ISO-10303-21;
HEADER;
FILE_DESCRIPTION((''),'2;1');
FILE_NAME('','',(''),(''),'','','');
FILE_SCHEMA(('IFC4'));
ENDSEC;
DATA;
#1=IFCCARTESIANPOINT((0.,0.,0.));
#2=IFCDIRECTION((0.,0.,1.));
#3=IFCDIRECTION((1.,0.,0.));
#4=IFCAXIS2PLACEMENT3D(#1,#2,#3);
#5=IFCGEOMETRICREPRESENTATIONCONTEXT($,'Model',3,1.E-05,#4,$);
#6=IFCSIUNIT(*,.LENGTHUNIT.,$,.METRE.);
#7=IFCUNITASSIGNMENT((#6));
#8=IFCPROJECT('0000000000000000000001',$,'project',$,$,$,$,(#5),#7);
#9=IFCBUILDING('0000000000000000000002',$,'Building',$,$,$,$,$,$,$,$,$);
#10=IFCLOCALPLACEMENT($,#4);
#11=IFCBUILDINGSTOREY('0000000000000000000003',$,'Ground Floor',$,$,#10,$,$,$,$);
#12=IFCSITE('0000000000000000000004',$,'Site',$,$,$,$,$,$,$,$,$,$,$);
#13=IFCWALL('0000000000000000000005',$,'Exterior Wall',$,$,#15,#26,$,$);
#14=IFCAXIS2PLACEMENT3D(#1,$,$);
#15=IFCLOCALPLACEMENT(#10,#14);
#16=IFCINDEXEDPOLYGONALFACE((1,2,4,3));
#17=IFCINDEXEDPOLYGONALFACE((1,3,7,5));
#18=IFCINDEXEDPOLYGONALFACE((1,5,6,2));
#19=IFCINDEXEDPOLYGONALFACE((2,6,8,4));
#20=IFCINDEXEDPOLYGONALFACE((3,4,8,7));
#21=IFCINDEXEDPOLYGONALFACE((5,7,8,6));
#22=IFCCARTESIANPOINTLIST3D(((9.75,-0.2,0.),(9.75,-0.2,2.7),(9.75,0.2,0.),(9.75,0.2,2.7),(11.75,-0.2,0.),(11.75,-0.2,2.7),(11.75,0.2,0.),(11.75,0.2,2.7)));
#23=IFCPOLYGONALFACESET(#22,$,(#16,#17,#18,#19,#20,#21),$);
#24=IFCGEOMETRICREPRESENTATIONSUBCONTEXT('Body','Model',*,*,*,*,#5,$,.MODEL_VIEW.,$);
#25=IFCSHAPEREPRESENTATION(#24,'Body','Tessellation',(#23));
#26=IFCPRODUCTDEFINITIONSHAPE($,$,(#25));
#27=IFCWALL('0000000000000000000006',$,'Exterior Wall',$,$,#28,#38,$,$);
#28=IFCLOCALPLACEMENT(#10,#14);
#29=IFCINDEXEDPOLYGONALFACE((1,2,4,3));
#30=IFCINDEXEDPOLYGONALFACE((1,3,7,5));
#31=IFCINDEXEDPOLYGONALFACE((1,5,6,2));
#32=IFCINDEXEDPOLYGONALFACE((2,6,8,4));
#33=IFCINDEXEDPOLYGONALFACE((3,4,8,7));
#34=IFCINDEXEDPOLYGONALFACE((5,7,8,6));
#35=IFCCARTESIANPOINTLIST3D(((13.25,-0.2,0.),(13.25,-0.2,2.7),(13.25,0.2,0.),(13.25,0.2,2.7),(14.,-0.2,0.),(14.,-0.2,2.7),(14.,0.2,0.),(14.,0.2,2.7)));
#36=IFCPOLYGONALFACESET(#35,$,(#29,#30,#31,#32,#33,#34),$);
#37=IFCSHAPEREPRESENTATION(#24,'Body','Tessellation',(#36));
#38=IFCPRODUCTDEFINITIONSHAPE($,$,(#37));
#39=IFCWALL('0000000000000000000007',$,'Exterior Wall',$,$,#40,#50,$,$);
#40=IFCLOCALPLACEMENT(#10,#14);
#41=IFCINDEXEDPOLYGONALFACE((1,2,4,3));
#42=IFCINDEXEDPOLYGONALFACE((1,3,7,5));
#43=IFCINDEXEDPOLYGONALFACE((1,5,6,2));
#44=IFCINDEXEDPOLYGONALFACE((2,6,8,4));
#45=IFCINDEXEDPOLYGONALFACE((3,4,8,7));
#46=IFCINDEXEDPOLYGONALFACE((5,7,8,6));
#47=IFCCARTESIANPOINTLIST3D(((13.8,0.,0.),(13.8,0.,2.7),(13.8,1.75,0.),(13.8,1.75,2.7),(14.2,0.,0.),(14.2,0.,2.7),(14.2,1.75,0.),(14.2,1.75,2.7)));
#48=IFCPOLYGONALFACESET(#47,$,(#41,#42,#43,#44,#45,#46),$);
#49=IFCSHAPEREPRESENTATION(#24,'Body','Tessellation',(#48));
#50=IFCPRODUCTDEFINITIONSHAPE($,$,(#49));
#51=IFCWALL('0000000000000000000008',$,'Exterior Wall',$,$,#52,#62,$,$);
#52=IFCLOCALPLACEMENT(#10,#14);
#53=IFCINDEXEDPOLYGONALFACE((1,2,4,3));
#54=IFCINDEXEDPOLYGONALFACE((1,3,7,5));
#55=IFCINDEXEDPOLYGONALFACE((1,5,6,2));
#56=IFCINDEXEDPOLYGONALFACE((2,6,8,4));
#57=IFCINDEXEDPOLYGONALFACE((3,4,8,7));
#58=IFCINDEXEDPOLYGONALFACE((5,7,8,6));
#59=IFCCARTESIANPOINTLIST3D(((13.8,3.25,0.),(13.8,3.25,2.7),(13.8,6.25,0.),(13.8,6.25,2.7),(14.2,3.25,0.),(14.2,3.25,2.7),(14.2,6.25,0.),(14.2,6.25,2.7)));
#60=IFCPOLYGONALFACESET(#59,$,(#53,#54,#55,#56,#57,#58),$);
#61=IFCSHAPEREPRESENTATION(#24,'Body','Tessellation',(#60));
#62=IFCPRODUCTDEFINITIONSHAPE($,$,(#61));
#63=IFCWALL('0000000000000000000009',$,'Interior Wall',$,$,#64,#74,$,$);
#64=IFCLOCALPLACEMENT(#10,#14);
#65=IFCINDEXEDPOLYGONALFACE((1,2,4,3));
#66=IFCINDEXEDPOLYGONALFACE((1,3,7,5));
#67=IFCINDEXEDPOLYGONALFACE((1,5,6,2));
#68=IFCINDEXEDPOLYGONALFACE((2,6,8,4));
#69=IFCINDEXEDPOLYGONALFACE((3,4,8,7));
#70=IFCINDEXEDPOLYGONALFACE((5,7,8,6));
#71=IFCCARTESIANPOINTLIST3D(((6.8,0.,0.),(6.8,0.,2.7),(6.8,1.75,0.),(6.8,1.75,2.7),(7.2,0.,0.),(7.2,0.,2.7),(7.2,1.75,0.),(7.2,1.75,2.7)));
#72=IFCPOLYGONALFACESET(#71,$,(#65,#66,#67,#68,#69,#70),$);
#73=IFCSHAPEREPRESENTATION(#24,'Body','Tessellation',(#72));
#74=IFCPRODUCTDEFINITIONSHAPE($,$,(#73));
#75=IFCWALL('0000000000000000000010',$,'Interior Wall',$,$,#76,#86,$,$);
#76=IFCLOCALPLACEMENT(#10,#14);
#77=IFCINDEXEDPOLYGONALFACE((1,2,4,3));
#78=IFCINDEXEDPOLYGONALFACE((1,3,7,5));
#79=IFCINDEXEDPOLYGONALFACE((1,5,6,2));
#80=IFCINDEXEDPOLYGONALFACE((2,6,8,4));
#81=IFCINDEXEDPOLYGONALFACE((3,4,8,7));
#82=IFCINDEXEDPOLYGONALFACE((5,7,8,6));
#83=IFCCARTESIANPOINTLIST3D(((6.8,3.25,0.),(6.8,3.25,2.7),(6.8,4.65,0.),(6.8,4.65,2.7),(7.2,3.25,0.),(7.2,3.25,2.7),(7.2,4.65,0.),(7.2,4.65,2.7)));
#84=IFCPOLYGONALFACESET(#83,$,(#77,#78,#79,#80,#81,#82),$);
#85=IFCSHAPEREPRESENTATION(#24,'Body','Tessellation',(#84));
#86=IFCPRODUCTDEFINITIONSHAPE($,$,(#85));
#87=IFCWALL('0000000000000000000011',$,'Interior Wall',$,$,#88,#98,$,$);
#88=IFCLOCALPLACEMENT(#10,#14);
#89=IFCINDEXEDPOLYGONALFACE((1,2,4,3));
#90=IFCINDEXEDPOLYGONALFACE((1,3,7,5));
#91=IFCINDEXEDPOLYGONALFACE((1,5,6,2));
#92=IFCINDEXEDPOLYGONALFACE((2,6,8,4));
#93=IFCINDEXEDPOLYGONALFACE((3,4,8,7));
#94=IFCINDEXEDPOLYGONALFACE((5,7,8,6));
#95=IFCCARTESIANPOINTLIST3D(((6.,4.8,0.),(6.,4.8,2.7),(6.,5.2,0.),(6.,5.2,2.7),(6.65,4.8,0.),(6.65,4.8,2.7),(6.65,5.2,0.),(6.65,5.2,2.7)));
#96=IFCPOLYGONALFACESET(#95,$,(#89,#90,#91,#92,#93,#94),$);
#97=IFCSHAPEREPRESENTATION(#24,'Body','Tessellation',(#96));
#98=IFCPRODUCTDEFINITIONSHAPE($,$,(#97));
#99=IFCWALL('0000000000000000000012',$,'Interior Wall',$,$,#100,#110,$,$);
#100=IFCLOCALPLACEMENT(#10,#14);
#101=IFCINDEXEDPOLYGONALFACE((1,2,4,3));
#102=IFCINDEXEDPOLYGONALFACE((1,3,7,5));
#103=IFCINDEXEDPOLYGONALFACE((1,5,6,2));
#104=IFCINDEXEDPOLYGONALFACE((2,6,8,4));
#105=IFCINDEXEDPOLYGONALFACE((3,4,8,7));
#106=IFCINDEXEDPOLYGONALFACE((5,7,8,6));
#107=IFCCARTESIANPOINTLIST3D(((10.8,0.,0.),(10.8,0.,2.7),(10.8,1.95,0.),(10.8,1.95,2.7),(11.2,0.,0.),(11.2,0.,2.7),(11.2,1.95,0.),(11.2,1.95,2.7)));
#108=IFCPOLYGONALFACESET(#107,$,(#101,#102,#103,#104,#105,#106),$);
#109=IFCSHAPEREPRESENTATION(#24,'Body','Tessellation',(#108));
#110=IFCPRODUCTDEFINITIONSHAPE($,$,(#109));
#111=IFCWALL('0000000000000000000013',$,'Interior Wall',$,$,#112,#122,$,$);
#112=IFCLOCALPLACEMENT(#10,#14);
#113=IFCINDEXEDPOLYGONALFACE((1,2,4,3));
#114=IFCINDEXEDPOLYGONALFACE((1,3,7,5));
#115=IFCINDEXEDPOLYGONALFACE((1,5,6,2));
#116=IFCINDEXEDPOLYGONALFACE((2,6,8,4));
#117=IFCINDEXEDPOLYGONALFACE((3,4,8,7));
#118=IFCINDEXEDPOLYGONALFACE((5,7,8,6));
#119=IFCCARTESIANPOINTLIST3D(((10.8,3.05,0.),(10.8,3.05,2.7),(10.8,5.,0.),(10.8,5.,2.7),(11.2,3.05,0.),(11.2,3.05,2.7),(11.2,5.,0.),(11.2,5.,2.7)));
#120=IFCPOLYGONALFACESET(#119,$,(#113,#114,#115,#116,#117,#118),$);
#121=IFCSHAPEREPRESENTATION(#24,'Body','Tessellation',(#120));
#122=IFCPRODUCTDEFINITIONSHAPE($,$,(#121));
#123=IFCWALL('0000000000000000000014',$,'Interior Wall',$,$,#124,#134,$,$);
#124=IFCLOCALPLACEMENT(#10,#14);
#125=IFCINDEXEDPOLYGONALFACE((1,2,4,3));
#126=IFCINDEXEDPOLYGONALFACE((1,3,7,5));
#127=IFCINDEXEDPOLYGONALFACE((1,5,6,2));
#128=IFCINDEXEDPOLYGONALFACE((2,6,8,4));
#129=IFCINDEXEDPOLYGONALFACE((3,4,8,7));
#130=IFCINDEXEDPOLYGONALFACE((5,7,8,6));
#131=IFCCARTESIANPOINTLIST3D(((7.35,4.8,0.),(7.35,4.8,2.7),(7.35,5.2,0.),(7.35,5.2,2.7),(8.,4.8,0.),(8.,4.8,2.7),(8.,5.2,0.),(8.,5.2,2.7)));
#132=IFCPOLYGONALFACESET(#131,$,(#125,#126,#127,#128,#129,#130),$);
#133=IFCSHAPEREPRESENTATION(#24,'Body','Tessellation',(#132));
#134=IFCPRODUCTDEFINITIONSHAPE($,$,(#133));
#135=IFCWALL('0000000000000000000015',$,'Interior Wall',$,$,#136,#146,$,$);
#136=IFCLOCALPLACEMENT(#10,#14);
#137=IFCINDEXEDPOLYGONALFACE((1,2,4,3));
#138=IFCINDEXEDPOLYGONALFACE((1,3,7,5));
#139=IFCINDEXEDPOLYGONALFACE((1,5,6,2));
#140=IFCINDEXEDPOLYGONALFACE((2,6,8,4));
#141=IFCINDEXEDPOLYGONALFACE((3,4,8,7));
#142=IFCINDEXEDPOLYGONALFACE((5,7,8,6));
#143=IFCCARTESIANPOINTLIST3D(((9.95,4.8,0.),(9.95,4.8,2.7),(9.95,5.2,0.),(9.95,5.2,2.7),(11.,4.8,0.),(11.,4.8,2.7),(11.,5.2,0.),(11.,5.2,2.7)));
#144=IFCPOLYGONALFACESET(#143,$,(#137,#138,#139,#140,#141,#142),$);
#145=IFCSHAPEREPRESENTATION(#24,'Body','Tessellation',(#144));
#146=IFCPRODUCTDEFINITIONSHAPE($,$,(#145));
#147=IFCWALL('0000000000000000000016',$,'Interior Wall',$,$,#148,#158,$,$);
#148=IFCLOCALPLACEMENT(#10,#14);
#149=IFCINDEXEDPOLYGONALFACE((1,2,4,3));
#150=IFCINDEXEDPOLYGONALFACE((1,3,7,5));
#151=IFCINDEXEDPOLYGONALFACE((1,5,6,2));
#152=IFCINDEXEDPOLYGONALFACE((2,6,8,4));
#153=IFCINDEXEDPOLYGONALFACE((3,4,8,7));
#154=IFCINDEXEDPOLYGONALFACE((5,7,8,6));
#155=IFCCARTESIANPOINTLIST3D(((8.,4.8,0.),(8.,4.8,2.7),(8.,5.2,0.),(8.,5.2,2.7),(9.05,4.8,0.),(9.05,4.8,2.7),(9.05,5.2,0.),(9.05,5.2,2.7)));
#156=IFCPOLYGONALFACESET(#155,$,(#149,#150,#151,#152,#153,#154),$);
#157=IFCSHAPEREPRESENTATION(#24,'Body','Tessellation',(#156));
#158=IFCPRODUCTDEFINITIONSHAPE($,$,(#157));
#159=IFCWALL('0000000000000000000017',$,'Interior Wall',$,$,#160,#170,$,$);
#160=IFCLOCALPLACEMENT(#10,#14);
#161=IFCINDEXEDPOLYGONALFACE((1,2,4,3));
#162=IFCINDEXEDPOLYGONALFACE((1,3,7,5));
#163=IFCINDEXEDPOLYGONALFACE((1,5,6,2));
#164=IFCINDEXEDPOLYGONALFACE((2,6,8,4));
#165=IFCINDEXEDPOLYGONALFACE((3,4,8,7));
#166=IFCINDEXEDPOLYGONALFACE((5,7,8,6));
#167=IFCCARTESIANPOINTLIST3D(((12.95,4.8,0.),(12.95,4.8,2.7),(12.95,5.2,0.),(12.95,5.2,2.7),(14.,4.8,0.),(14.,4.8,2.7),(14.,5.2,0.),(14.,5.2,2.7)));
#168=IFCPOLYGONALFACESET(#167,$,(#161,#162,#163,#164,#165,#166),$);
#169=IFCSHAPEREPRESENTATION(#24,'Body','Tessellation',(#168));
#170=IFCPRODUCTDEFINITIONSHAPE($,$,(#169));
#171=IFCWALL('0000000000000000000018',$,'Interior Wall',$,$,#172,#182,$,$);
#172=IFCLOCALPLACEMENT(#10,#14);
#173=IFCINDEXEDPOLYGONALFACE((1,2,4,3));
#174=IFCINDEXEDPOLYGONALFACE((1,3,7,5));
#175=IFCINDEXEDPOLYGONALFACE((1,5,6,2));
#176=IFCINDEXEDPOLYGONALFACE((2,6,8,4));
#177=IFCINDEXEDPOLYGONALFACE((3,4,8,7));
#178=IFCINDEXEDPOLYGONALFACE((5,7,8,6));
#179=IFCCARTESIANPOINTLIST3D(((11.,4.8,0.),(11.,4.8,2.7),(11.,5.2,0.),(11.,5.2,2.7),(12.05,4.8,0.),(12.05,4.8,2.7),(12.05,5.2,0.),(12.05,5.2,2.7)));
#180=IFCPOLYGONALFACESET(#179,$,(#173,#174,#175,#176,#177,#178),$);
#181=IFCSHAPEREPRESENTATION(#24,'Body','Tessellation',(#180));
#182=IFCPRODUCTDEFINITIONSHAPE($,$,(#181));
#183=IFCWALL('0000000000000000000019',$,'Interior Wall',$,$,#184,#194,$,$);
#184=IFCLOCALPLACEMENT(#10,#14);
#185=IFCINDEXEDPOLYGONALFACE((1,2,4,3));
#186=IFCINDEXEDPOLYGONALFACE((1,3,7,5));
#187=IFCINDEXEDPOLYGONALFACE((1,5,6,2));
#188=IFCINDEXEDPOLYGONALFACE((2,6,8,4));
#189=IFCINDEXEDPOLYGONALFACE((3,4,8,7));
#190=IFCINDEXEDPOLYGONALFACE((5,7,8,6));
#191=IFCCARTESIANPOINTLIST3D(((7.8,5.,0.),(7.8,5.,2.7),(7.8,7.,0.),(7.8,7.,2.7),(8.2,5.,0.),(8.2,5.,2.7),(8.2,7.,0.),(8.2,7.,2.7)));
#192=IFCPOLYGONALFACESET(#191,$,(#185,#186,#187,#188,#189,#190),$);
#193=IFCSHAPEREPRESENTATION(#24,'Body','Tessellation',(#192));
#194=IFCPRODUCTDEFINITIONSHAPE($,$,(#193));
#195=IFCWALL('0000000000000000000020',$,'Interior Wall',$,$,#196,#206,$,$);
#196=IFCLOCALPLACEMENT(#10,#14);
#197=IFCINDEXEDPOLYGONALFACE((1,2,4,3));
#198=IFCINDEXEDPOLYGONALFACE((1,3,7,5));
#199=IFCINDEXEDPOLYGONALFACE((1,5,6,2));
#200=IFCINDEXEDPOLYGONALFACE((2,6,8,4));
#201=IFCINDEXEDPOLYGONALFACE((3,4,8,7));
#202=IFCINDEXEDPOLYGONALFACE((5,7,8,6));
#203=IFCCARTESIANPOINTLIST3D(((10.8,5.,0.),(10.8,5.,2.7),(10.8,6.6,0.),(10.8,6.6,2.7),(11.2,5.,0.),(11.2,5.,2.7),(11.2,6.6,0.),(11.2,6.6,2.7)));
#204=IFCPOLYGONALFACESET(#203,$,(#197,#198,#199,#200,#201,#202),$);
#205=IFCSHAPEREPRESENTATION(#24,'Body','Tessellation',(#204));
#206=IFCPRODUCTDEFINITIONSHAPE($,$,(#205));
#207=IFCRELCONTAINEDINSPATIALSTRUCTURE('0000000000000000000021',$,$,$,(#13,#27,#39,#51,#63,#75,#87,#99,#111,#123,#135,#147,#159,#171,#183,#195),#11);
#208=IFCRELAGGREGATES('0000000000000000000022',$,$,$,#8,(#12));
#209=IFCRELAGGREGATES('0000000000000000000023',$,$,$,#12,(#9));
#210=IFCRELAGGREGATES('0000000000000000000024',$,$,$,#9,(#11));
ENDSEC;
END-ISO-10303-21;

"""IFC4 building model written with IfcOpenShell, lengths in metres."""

from ifc_helpers import new_model, si_unit, frame, origin_with_axes, place, context, subcontext, project, spatial, indexed_curve, outline, extrude, element, save


model = new_model("IFC4")

# Units and contexts
model_context = context("Model", 3, precision=1e-05, world=origin_with_axes())
body_context = subcontext(model_context, "Body", "Model", "MODEL_VIEW")
ifc_project = project(units=[si_unit("LENGTHUNIT", "METRE")], contexts=[model_context])

# Site, building, storey
site = spatial("IfcSite", under=ifc_project, Name="Site")
building = spatial("IfcBuilding", under=site, Name="Building")
storey_placement = place(None, origin_with_axes())
storey = spatial("IfcBuildingStorey", under=building, at=storey_placement, Name="Ground Floor")

# Walls
wall_1_placement = place(storey_placement, frame((9.75, 0.0, 0.0), z_axis=(0.0, 0.0, 1.0), x_axis=(1.0, 0.0, 0.0)))
element("IfcWall", 1, at=wall_1_placement, inside=storey, Name="Exterior Wall", context=body_context, shape_type="SweptSolid", body=[
    extrude(outline(indexed_curve([(0.0, 0.0), (0.0, 0.4), (2.0, 0.4), (2.0, 0.0), (0.0, 0.0)], self_intersect=False)), frame((0.0, -0.2, 0.0), z_axis=(0.0, 0.0, 1.0), x_axis=(1.0, 0.0, 0.0)), (0.0, 0.0, 1.0), 2.7),
])
wall_2_placement = place(storey_placement, frame((13.25, 0.0, 0.0), z_axis=(0.0, 0.0, 1.0), x_axis=(1.0, 0.0, 0.0)))
element("IfcWall", 2, at=wall_2_placement, inside=storey, Name="Exterior Wall", context=body_context, shape_type="SweptSolid", body=[
    extrude(outline(indexed_curve([(0.0, 0.0), (0.0, 0.4), (0.75, 0.4), (0.75, 0.0), (0.0, 0.0)], self_intersect=False)), frame((0.0, -0.2, 0.0), z_axis=(0.0, 0.0, 1.0), x_axis=(1.0, 0.0, 0.0)), (0.0, 0.0, 1.0), 2.7),
])
wall_3_placement = place(storey_placement, frame((14.0, 0.0, 0.0), z_axis=(0.0, 0.0, 1.0), x_axis=(0.0, 1.0, 0.0)))
element("IfcWall", 3, at=wall_3_placement, inside=storey, Name="Exterior Wall", context=body_context, shape_type="SweptSolid", body=[
    extrude(outline(indexed_curve([(0.0, 0.0), (0.0, 0.4), (1.75, 0.4), (1.75, 0.0), (0.0, 0.0)], self_intersect=False)), frame((0.0, -0.2, 0.0), z_axis=(0.0, 0.0, 1.0), x_axis=(1.0, 0.0, 0.0)), (0.0, 0.0, 1.0), 2.7),
])
wall_4_placement = place(storey_placement, frame((14.0, 3.25, 0.0), z_axis=(0.0, 0.0, 1.0), x_axis=(0.0, 1.0, 0.0)))
element("IfcWall", 4, at=wall_4_placement, inside=storey, Name="Exterior Wall", context=body_context, shape_type="SweptSolid", body=[
    extrude(outline(indexed_curve([(0.0, 0.0), (0.0, 0.4), (3.0, 0.4), (3.0, 0.0), (0.0, 0.0)], self_intersect=False)), frame((0.0, -0.2, 0.0), z_axis=(0.0, 0.0, 1.0), x_axis=(1.0, 0.0, 0.0)), (0.0, 0.0, 1.0), 2.7),
])
wall_5_placement = place(storey_placement, frame((7.0, 0.0, 0.0), z_axis=(0.0, 0.0, 1.0), x_axis=(0.0, 1.0, 0.0)))
element("IfcWall", 5, at=wall_5_placement, inside=storey, Name="Interior Wall", context=body_context, shape_type="SweptSolid", body=[
    extrude(outline(indexed_curve([(0.0, 0.0), (0.0, 0.4), (1.75, 0.4), (1.75, 0.0), (0.0, 0.0)], self_intersect=False)), frame((0.0, -0.2, 0.0), z_axis=(0.0, 0.0, 1.0), x_axis=(1.0, 0.0, 0.0)), (0.0, 0.0, 1.0), 2.7),
])
wall_6_placement = place(storey_placement, frame((7.0, 3.25, 0.0), z_axis=(0.0, 0.0, 1.0), x_axis=(0.0, 1.0, 0.0)))
element("IfcWall", 6, at=wall_6_placement, inside=storey, Name="Interior Wall", context=body_context, shape_type="SweptSolid", body=[
    extrude(outline(indexed_curve([(0.0, 0.0), (0.0, 0.4), (1.4, 0.4), (1.4, 0.0), (0.0, 0.0)], self_intersect=False)), frame((0.0, -0.2, 0.0), z_axis=(0.0, 0.0, 1.0), x_axis=(1.0, 0.0, 0.0)), (0.0, 0.0, 1.0), 2.7),
])
wall_7_placement = place(storey_placement, frame((6.65, 5.0, 0.0), z_axis=(0.0, 0.0, 1.0), x_axis=(-1.0, 0.0, 0.0)))
element("IfcWall", 7, at=wall_7_placement, inside=storey, Name="Interior Wall", context=body_context, shape_type="SweptSolid", body=[
    extrude(outline(indexed_curve([(0.0, 0.0), (0.0, 0.4), (0.65, 0.4), (0.65, 0.0), (0.0, 0.0)], self_intersect=False)), frame((0.0, -0.2, 0.0), z_axis=(0.0, 0.0, 1.0), x_axis=(1.0, 0.0, 0.0)), (0.0, 0.0, 1.0), 2.7),
])
wall_8_placement = place(storey_placement, frame((11.0, 0.0, 0.0), z_axis=(0.0, 0.0, 1.0), x_axis=(0.0, 1.0, 0.0)))
element("IfcWall", 8, at=wall_8_placement, inside=storey, Name="Interior Wall", context=body_context, shape_type="SweptSolid", body=[
    extrude(outline(indexed_curve([(0.0, 0.0), (0.0, 0.4), (1.95, 0.4), (1.95, 0.0), (0.0, 0.0)], self_intersect=False)), frame((0.0, -0.2, 0.0), z_axis=(0.0, 0.0, 1.0), x_axis=(1.0, 0.0, 0.0)), (0.0, 0.0, 1.0), 2.7),
])
wall_9_placement = place(storey_placement, frame((11.0, 3.05, 0.0), z_axis=(0.0, 0.0, 1.0), x_axis=(0.0, 1.0, 0.0)))
element("IfcWall", 9, at=wall_9_placement, inside=storey, Name="Interior Wall", context=body_context, shape_type="SweptSolid", body=[
    extrude(outline(indexed_curve([(0.0, 0.0), (0.0, 0.4), (1.95, 0.4), (1.95, 0.0), (0.0, 0.0)], self_intersect=False)), frame((0.0, -0.2, 0.0), z_axis=(0.0, 0.0, 1.0), x_axis=(1.0, 0.0, 0.0)), (0.0, 0.0, 1.0), 2.7),
])
wall_10_placement = place(storey_placement, frame((8.0, 5.0, 0.0), z_axis=(0.0, 0.0, 1.0), x_axis=(-1.0, 0.0, 0.0)))
element("IfcWall", 10, at=wall_10_placement, inside=storey, Name="Interior Wall", context=body_context, shape_type="SweptSolid", body=[
    extrude(outline(indexed_curve([(0.0, 0.0), (0.0, 0.4), (0.65, 0.4), (0.65, 0.0), (0.0, 0.0)], self_intersect=False)), frame((0.0, -0.2, 0.0), z_axis=(0.0, 0.0, 1.0), x_axis=(1.0, 0.0, 0.0)), (0.0, 0.0, 1.0), 2.7),
])
for number, where, z_axis, x_axis, name in (
    (11, (11.0, 5.0, 0.0), (0.0, 0.0, 1.0), (-1.0, 0.0, 0.0), "Interior Wall"),
    (12, (9.05, 5.0, 0.0), (0.0, 0.0, 1.0), (-1.0, 0.0, 0.0), "Interior Wall"),
    (13, (14.0, 5.0, 0.0), (0.0, 0.0, 1.0), (-1.0, 0.0, 0.0), "Interior Wall"),
    (14, (12.05, 5.0, 0.0), (0.0, 0.0, 1.0), (-1.0, 0.0, 0.0), "Interior Wall"),
):
    element("IfcWall", number, at=place(storey_placement, frame(where, z_axis=z_axis, x_axis=x_axis)), inside=storey, Name=name, context=body_context, shape_type="SweptSolid", body=[
        extrude(outline(indexed_curve([(0.0, 0.0), (0.0, 0.4), (1.05, 0.4), (1.05, 0.0), (0.0, 0.0)], self_intersect=False)), frame((0.0, -0.2, 0.0), z_axis=(0.0, 0.0, 1.0), x_axis=(1.0, 0.0, 0.0)), (0.0, 0.0, 1.0), 2.7),
    ])
wall_11_placement = place(storey_placement, frame((8.0, 5.0, 0.0), z_axis=(0.0, 0.0, 1.0), x_axis=(0.0, 1.0, 0.0)))
element("IfcWall", 15, at=wall_11_placement, inside=storey, Name="Interior Wall", context=body_context, shape_type="SweptSolid", body=[
    extrude(outline(indexed_curve([(0.0, 0.0), (0.0, 0.4), (2.0, 0.4), (2.0, 0.0), (0.0, 0.0)], self_intersect=False)), frame((0.0, -0.2, 0.0), z_axis=(0.0, 0.0, 1.0), x_axis=(1.0, 0.0, 0.0)), (0.0, 0.0, 1.0), 2.7),
])
wall_12_placement = place(storey_placement, frame((11.0, 5.0, 0.0), z_axis=(0.0, 0.0, 1.0), x_axis=(0.0, 1.0, 0.0)))
element("IfcWall", 16, at=wall_12_placement, inside=storey, Name="Interior Wall", context=body_context, shape_type="SweptSolid", body=[
    extrude(outline(indexed_curve([(0.0, 0.0), (0.0, 0.4), (1.6, 0.4), (1.6, 0.0), (0.0, 0.0)], self_intersect=False)), frame((0.0, -0.2, 0.0), z_axis=(0.0, 0.0, 1.0), x_axis=(1.0, 0.0, 0.0)), (0.0, 0.0, 1.0), 2.7),
])

save(model, "model.ifc")
